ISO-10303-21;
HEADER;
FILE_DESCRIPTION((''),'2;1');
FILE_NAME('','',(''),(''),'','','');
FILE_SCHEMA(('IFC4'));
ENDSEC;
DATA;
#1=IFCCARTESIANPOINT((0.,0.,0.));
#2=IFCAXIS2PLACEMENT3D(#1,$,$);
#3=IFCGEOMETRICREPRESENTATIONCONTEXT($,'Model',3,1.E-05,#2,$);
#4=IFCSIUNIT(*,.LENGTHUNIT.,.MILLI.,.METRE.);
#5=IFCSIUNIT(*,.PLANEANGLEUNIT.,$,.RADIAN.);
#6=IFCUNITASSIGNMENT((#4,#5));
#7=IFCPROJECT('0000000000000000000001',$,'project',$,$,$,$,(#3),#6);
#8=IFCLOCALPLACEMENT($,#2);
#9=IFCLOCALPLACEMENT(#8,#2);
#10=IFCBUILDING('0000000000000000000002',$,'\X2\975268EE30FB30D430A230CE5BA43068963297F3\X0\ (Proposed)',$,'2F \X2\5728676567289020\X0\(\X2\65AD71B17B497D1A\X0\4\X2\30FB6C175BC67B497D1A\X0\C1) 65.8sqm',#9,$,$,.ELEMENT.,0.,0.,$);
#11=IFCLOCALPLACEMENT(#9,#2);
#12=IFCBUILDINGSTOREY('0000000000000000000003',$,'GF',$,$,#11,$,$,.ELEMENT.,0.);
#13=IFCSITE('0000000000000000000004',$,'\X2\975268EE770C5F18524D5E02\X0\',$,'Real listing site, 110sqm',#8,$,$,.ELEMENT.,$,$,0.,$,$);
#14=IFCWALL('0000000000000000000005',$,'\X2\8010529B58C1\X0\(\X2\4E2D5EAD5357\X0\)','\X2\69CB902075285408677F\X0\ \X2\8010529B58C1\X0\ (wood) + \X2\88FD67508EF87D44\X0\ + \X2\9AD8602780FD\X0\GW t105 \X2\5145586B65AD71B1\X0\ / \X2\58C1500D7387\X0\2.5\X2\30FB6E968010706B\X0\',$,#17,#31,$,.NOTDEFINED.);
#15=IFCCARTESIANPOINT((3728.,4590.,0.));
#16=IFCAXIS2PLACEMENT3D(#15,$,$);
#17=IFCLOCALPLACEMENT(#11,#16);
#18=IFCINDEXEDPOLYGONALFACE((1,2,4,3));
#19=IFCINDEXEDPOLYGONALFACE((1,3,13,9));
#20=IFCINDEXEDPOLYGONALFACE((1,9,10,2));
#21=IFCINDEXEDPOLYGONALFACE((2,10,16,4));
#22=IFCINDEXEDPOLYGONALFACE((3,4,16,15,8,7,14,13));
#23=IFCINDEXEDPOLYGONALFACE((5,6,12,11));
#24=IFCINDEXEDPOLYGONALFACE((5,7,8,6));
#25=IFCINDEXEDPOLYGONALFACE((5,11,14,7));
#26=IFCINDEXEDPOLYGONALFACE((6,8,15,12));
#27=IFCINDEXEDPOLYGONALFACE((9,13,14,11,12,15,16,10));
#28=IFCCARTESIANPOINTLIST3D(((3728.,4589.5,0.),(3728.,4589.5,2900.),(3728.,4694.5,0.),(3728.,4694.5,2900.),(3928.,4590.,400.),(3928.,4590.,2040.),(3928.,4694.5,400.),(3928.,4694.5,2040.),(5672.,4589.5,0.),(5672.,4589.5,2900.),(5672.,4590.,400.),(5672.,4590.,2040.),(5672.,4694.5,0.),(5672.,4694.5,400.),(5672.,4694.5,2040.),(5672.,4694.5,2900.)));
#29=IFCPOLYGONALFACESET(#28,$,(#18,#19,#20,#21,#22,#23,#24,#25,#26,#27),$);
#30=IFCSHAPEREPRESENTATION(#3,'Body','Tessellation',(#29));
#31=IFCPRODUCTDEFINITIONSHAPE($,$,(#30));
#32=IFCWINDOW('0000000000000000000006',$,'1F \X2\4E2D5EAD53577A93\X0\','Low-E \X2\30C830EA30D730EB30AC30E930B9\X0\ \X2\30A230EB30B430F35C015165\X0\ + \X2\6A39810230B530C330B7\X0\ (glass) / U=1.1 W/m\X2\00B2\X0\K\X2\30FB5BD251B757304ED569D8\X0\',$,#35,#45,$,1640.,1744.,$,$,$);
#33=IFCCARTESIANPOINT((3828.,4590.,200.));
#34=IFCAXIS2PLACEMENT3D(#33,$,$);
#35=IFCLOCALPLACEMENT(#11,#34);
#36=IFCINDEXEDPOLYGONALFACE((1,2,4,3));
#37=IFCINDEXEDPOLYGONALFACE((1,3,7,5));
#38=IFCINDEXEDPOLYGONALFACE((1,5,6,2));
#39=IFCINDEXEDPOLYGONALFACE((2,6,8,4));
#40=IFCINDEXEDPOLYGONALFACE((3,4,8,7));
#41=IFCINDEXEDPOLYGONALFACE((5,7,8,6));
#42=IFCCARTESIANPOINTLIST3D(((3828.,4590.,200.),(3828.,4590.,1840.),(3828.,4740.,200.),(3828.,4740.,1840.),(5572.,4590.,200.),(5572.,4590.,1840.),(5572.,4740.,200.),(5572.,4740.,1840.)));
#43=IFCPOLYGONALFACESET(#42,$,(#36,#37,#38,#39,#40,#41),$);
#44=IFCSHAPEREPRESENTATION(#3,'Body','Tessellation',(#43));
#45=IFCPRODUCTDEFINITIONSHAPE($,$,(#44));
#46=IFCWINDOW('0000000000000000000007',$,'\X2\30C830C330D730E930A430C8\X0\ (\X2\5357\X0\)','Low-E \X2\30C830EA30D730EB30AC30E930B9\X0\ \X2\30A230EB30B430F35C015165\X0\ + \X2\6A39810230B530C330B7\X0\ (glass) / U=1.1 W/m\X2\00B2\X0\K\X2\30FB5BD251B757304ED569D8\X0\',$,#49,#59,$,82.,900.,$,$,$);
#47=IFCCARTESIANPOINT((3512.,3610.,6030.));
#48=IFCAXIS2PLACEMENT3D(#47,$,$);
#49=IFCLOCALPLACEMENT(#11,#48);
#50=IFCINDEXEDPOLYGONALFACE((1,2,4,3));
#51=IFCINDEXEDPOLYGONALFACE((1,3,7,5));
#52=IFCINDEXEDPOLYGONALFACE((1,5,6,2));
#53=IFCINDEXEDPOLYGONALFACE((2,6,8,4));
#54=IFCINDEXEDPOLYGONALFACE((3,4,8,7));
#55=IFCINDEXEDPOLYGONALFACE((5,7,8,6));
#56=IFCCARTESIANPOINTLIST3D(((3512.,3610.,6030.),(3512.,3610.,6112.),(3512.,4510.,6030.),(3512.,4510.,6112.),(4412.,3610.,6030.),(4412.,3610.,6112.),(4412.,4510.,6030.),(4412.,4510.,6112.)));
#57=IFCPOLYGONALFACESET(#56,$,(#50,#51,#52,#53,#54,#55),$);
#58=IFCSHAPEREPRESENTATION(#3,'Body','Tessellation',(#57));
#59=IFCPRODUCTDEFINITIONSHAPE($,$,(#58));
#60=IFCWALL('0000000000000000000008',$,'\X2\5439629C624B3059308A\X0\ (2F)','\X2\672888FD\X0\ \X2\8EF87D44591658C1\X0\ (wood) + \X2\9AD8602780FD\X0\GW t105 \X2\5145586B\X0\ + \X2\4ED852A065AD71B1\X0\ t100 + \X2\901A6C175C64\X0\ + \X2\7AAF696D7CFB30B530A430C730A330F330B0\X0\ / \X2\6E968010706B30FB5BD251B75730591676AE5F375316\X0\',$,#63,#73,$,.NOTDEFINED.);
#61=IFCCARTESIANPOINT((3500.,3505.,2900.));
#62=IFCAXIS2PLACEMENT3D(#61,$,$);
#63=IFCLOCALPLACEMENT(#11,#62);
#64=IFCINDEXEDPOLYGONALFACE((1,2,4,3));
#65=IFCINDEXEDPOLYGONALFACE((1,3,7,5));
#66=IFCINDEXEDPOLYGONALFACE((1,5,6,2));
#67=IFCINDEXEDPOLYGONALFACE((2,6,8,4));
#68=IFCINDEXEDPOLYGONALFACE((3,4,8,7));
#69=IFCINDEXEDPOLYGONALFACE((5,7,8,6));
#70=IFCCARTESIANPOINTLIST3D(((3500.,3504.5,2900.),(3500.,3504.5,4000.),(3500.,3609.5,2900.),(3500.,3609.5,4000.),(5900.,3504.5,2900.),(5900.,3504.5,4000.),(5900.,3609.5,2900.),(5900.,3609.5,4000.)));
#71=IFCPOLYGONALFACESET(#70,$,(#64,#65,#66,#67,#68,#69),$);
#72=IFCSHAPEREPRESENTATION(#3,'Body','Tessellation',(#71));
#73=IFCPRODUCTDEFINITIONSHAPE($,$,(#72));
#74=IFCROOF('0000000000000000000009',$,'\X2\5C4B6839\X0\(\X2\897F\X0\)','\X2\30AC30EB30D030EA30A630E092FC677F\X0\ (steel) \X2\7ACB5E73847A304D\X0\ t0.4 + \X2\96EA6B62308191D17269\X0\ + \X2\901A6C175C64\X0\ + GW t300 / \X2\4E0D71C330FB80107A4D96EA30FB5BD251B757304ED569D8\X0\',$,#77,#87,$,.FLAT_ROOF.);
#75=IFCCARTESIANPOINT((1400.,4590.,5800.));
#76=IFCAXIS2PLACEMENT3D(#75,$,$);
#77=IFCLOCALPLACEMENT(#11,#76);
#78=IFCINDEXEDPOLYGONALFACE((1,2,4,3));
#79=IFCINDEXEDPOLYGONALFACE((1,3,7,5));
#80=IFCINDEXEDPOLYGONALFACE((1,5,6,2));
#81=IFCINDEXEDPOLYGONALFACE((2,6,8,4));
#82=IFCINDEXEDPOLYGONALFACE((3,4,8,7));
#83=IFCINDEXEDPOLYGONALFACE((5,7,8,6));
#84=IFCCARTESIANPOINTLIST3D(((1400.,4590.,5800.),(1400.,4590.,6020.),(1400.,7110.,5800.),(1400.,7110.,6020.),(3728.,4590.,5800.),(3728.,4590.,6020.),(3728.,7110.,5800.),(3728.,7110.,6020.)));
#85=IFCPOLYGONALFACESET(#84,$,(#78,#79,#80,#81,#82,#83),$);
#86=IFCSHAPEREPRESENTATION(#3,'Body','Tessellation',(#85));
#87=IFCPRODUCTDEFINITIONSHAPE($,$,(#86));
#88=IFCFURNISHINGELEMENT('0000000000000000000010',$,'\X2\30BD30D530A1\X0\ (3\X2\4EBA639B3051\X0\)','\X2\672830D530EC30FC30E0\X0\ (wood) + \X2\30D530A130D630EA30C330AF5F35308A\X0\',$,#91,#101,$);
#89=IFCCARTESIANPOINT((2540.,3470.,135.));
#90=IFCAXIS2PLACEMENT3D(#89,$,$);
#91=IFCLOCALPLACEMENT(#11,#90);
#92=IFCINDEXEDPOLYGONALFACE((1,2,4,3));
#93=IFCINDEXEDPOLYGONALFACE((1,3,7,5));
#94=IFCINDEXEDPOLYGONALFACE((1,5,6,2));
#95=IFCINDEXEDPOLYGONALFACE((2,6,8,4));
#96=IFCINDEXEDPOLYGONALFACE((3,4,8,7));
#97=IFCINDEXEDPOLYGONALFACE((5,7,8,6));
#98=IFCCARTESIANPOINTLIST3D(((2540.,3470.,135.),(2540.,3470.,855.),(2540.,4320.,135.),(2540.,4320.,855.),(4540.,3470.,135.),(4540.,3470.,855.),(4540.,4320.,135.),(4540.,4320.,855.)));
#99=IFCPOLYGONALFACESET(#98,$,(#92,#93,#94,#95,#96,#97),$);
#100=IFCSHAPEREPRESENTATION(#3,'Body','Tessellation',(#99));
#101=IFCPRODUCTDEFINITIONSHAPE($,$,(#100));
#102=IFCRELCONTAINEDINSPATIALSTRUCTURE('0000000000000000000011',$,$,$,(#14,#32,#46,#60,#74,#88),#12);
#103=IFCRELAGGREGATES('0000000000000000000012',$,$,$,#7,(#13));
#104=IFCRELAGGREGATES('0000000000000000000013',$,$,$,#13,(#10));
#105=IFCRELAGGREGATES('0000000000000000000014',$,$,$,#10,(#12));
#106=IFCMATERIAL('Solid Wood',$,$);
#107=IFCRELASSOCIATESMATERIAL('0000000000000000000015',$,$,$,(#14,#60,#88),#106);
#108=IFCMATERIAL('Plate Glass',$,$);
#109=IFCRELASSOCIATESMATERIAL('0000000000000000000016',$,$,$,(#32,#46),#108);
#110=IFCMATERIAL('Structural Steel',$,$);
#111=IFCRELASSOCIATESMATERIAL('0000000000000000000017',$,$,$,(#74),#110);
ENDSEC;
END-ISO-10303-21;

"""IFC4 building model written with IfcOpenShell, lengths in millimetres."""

from ifc_helpers import new_model, si_unit, frame, frame_2d, origin, place, context, project, spatial, rectangle, extrude, material, element, fill, save


model = new_model("IFC4")

# Units and contexts
model_context = context("Model", 3, precision=1e-05, world=origin())
ifc_project = project(units=[si_unit("LENGTHUNIT", "METRE", prefix="MILLI"), si_unit("PLANEANGLEUNIT", "RADIAN")], contexts=[model_context])

# Site, building, storey
site_placement = place(None, origin())
site = spatial("IfcSite", under=ifc_project, at=site_placement, Name="青森県弘前市", ObjectType="Real listing site, 110sqm", CompositionType="ELEMENT", RefElevation=0.0)
building_placement = place(site_placement, origin())
building = spatial("IfcBuilding", under=site, at=building_placement, Name="青森・ピアノ室と防音 (Proposed)", ObjectType="2F 在来木造(断熱等級4・気密等級C1) 65.8sqm", CompositionType="ELEMENT", ElevationOfRefHeight=0.0, ElevationOfTerrain=0.0)
storey_placement = place(building_placement, origin())
storey = spatial("IfcBuildingStorey", under=building, at=storey_placement, Name="GF", CompositionType="ELEMENT", Elevation=0.0)

# Shared definitions
ifc_material_1 = material(Name="Solid Wood")

# Wall, opening, window
wall_1_placement = place(storey_placement, frame((3728.0, 4590.0, 0.0)))
wall_1 = element("IfcWall", 1, at=wall_1_placement, inside=storey, material=ifc_material_1, Name="耐力壁(中庭南)", Description="構造用合板 耐力壁 (wood) + 製材軸組 + 高性能GW t105 充填断熱 / 壁倍率2.5・準耐火", PredefinedType="NOTDEFINED", context=model_context, shape_type="SweptSolid", body=[
    extrude(rectangle(XDim=1944.0, YDim=105.0, at=frame_2d((972.0, 52.0))), frame((3728.0, 4590.0, 0.0)), (0.0, 0.0, 1.0), 2900.0),
])
opening_placement = place(storey_placement, frame((3828.0, 4590.0, 200.0)))
opening = element("IfcOpeningElement", 2, at=opening_placement, cuts=wall_1, PredefinedType="NOTDEFINED", context=model_context, shape_type="SweptSolid", body=[
    extrude(rectangle(XDim=1744.0, YDim=150.0, at=frame_2d((872.0, 75.0))), frame((3828.0, 4590.0, 200.0)), (0.0, 0.0, 1.0), 1640.0),
])
ifc_material_2 = material(Name="Plate Glass")
window_1_placement = place(storey_placement, frame((3828.0, 4590.0, 200.0)))
window_1 = element("IfcWindow", 3, at=window_1_placement, inside=storey, material=ifc_material_2, Name="1F 中庭南窓", Description="Low-E トリプルガラス アルゴン封入 + 樹脂サッシ (glass) / U=1.1 W/m²K・寒冷地仕様", OverallHeight=1640.0, OverallWidth=1744.0, context=model_context, shape_type="SweptSolid", body=[
    extrude(rectangle(XDim=1744.0, YDim=150.0, at=frame_2d((872.0, 75.0))), frame((3828.0, 4590.0, 200.0)), (0.0, 0.0, 1.0), 1640.0),
])
fill(opening, window_1)

# Window
window_2_placement = place(storey_placement, frame((3512.0, 3610.0, 6030.0)))
element("IfcWindow", 4, at=window_2_placement, inside=storey, material=ifc_material_2, Name="トップライト (南)", Description="Low-E トリプルガラス アルゴン封入 + 樹脂サッシ (glass) / U=1.1 W/m²K・寒冷地仕様", OverallHeight=82.0, OverallWidth=900.0, context=model_context, shape_type="SweptSolid", body=[
    extrude(rectangle(XDim=900.0, YDim=900.0, at=frame_2d((450.0, 450.0))), frame((3512.0, 3610.0, 6030.0)), (0.0, 0.0, 1.0), 82.0),
])

# Wall
wall_2_placement = place(storey_placement, frame((3500.0, 3505.0, 2900.0)))
element("IfcWall", 5, at=wall_2_placement, inside=storey, material=ifc_material_1, Name="吹抜手すり (2F)", Description="木製 軸組外壁 (wood) + 高性能GW t105 充填 + 付加断熱 t100 + 通気層 + 窯業系サイディング / 準耐火・寒冷地外皮強化", PredefinedType="NOTDEFINED", context=model_context, shape_type="SweptSolid", body=[
    extrude(rectangle(XDim=2400.0, YDim=105.0, at=frame_2d((1200.0, 52.0))), frame((3500.0, 3505.0, 2900.0)), (0.0, 0.0, 1.0), 1100.0),
])

# Roof
ifc_material_3 = material(Name="Structural Steel")
for number, where, name in (
    (6, (1400.0, 4590.0, 5800.0), "屋根(西)"),
):
    element("IfcRoof", number, at=place(storey_placement, frame(where)), inside=storey, material=ifc_material_3, Name=name, Description="ガルバリウム鋼板 (steel) 立平葺き t0.4 + 雪止め金物 + 通気層 + GW t300 / 不燃・耐積雪・寒冷地仕様", PredefinedType="FLAT_ROOF", context=model_context, shape_type="SweptSolid", body=[
        extrude(rectangle(XDim=2328.0, YDim=2520.0, at=frame_2d((1164.0, 1260.0))), frame((1400.0, 4590.0, 5800.0)), (0.0, 0.0, 1.0), 220.0),
    ])

# Furnishing element
furnishing_placement = place(storey_placement, frame((2540.0, 3470.0, 135.0)))
element("IfcFurnishingElement", 7, at=furnishing_placement, inside=storey, material=ifc_material_1, Name="ソファ (3人掛け)", Description="木フレーム (wood) + ファブリック張り", context=model_context, shape_type="SweptSolid", body=[
    extrude(rectangle(XDim=2000.0, YDim=850.0, at=frame_2d((1000.0, 425.0))), frame((2540.0, 3470.0, 135.0)), (0.0, 0.0, 1.0), 720.0),
])

save(model, "model.ifc")
